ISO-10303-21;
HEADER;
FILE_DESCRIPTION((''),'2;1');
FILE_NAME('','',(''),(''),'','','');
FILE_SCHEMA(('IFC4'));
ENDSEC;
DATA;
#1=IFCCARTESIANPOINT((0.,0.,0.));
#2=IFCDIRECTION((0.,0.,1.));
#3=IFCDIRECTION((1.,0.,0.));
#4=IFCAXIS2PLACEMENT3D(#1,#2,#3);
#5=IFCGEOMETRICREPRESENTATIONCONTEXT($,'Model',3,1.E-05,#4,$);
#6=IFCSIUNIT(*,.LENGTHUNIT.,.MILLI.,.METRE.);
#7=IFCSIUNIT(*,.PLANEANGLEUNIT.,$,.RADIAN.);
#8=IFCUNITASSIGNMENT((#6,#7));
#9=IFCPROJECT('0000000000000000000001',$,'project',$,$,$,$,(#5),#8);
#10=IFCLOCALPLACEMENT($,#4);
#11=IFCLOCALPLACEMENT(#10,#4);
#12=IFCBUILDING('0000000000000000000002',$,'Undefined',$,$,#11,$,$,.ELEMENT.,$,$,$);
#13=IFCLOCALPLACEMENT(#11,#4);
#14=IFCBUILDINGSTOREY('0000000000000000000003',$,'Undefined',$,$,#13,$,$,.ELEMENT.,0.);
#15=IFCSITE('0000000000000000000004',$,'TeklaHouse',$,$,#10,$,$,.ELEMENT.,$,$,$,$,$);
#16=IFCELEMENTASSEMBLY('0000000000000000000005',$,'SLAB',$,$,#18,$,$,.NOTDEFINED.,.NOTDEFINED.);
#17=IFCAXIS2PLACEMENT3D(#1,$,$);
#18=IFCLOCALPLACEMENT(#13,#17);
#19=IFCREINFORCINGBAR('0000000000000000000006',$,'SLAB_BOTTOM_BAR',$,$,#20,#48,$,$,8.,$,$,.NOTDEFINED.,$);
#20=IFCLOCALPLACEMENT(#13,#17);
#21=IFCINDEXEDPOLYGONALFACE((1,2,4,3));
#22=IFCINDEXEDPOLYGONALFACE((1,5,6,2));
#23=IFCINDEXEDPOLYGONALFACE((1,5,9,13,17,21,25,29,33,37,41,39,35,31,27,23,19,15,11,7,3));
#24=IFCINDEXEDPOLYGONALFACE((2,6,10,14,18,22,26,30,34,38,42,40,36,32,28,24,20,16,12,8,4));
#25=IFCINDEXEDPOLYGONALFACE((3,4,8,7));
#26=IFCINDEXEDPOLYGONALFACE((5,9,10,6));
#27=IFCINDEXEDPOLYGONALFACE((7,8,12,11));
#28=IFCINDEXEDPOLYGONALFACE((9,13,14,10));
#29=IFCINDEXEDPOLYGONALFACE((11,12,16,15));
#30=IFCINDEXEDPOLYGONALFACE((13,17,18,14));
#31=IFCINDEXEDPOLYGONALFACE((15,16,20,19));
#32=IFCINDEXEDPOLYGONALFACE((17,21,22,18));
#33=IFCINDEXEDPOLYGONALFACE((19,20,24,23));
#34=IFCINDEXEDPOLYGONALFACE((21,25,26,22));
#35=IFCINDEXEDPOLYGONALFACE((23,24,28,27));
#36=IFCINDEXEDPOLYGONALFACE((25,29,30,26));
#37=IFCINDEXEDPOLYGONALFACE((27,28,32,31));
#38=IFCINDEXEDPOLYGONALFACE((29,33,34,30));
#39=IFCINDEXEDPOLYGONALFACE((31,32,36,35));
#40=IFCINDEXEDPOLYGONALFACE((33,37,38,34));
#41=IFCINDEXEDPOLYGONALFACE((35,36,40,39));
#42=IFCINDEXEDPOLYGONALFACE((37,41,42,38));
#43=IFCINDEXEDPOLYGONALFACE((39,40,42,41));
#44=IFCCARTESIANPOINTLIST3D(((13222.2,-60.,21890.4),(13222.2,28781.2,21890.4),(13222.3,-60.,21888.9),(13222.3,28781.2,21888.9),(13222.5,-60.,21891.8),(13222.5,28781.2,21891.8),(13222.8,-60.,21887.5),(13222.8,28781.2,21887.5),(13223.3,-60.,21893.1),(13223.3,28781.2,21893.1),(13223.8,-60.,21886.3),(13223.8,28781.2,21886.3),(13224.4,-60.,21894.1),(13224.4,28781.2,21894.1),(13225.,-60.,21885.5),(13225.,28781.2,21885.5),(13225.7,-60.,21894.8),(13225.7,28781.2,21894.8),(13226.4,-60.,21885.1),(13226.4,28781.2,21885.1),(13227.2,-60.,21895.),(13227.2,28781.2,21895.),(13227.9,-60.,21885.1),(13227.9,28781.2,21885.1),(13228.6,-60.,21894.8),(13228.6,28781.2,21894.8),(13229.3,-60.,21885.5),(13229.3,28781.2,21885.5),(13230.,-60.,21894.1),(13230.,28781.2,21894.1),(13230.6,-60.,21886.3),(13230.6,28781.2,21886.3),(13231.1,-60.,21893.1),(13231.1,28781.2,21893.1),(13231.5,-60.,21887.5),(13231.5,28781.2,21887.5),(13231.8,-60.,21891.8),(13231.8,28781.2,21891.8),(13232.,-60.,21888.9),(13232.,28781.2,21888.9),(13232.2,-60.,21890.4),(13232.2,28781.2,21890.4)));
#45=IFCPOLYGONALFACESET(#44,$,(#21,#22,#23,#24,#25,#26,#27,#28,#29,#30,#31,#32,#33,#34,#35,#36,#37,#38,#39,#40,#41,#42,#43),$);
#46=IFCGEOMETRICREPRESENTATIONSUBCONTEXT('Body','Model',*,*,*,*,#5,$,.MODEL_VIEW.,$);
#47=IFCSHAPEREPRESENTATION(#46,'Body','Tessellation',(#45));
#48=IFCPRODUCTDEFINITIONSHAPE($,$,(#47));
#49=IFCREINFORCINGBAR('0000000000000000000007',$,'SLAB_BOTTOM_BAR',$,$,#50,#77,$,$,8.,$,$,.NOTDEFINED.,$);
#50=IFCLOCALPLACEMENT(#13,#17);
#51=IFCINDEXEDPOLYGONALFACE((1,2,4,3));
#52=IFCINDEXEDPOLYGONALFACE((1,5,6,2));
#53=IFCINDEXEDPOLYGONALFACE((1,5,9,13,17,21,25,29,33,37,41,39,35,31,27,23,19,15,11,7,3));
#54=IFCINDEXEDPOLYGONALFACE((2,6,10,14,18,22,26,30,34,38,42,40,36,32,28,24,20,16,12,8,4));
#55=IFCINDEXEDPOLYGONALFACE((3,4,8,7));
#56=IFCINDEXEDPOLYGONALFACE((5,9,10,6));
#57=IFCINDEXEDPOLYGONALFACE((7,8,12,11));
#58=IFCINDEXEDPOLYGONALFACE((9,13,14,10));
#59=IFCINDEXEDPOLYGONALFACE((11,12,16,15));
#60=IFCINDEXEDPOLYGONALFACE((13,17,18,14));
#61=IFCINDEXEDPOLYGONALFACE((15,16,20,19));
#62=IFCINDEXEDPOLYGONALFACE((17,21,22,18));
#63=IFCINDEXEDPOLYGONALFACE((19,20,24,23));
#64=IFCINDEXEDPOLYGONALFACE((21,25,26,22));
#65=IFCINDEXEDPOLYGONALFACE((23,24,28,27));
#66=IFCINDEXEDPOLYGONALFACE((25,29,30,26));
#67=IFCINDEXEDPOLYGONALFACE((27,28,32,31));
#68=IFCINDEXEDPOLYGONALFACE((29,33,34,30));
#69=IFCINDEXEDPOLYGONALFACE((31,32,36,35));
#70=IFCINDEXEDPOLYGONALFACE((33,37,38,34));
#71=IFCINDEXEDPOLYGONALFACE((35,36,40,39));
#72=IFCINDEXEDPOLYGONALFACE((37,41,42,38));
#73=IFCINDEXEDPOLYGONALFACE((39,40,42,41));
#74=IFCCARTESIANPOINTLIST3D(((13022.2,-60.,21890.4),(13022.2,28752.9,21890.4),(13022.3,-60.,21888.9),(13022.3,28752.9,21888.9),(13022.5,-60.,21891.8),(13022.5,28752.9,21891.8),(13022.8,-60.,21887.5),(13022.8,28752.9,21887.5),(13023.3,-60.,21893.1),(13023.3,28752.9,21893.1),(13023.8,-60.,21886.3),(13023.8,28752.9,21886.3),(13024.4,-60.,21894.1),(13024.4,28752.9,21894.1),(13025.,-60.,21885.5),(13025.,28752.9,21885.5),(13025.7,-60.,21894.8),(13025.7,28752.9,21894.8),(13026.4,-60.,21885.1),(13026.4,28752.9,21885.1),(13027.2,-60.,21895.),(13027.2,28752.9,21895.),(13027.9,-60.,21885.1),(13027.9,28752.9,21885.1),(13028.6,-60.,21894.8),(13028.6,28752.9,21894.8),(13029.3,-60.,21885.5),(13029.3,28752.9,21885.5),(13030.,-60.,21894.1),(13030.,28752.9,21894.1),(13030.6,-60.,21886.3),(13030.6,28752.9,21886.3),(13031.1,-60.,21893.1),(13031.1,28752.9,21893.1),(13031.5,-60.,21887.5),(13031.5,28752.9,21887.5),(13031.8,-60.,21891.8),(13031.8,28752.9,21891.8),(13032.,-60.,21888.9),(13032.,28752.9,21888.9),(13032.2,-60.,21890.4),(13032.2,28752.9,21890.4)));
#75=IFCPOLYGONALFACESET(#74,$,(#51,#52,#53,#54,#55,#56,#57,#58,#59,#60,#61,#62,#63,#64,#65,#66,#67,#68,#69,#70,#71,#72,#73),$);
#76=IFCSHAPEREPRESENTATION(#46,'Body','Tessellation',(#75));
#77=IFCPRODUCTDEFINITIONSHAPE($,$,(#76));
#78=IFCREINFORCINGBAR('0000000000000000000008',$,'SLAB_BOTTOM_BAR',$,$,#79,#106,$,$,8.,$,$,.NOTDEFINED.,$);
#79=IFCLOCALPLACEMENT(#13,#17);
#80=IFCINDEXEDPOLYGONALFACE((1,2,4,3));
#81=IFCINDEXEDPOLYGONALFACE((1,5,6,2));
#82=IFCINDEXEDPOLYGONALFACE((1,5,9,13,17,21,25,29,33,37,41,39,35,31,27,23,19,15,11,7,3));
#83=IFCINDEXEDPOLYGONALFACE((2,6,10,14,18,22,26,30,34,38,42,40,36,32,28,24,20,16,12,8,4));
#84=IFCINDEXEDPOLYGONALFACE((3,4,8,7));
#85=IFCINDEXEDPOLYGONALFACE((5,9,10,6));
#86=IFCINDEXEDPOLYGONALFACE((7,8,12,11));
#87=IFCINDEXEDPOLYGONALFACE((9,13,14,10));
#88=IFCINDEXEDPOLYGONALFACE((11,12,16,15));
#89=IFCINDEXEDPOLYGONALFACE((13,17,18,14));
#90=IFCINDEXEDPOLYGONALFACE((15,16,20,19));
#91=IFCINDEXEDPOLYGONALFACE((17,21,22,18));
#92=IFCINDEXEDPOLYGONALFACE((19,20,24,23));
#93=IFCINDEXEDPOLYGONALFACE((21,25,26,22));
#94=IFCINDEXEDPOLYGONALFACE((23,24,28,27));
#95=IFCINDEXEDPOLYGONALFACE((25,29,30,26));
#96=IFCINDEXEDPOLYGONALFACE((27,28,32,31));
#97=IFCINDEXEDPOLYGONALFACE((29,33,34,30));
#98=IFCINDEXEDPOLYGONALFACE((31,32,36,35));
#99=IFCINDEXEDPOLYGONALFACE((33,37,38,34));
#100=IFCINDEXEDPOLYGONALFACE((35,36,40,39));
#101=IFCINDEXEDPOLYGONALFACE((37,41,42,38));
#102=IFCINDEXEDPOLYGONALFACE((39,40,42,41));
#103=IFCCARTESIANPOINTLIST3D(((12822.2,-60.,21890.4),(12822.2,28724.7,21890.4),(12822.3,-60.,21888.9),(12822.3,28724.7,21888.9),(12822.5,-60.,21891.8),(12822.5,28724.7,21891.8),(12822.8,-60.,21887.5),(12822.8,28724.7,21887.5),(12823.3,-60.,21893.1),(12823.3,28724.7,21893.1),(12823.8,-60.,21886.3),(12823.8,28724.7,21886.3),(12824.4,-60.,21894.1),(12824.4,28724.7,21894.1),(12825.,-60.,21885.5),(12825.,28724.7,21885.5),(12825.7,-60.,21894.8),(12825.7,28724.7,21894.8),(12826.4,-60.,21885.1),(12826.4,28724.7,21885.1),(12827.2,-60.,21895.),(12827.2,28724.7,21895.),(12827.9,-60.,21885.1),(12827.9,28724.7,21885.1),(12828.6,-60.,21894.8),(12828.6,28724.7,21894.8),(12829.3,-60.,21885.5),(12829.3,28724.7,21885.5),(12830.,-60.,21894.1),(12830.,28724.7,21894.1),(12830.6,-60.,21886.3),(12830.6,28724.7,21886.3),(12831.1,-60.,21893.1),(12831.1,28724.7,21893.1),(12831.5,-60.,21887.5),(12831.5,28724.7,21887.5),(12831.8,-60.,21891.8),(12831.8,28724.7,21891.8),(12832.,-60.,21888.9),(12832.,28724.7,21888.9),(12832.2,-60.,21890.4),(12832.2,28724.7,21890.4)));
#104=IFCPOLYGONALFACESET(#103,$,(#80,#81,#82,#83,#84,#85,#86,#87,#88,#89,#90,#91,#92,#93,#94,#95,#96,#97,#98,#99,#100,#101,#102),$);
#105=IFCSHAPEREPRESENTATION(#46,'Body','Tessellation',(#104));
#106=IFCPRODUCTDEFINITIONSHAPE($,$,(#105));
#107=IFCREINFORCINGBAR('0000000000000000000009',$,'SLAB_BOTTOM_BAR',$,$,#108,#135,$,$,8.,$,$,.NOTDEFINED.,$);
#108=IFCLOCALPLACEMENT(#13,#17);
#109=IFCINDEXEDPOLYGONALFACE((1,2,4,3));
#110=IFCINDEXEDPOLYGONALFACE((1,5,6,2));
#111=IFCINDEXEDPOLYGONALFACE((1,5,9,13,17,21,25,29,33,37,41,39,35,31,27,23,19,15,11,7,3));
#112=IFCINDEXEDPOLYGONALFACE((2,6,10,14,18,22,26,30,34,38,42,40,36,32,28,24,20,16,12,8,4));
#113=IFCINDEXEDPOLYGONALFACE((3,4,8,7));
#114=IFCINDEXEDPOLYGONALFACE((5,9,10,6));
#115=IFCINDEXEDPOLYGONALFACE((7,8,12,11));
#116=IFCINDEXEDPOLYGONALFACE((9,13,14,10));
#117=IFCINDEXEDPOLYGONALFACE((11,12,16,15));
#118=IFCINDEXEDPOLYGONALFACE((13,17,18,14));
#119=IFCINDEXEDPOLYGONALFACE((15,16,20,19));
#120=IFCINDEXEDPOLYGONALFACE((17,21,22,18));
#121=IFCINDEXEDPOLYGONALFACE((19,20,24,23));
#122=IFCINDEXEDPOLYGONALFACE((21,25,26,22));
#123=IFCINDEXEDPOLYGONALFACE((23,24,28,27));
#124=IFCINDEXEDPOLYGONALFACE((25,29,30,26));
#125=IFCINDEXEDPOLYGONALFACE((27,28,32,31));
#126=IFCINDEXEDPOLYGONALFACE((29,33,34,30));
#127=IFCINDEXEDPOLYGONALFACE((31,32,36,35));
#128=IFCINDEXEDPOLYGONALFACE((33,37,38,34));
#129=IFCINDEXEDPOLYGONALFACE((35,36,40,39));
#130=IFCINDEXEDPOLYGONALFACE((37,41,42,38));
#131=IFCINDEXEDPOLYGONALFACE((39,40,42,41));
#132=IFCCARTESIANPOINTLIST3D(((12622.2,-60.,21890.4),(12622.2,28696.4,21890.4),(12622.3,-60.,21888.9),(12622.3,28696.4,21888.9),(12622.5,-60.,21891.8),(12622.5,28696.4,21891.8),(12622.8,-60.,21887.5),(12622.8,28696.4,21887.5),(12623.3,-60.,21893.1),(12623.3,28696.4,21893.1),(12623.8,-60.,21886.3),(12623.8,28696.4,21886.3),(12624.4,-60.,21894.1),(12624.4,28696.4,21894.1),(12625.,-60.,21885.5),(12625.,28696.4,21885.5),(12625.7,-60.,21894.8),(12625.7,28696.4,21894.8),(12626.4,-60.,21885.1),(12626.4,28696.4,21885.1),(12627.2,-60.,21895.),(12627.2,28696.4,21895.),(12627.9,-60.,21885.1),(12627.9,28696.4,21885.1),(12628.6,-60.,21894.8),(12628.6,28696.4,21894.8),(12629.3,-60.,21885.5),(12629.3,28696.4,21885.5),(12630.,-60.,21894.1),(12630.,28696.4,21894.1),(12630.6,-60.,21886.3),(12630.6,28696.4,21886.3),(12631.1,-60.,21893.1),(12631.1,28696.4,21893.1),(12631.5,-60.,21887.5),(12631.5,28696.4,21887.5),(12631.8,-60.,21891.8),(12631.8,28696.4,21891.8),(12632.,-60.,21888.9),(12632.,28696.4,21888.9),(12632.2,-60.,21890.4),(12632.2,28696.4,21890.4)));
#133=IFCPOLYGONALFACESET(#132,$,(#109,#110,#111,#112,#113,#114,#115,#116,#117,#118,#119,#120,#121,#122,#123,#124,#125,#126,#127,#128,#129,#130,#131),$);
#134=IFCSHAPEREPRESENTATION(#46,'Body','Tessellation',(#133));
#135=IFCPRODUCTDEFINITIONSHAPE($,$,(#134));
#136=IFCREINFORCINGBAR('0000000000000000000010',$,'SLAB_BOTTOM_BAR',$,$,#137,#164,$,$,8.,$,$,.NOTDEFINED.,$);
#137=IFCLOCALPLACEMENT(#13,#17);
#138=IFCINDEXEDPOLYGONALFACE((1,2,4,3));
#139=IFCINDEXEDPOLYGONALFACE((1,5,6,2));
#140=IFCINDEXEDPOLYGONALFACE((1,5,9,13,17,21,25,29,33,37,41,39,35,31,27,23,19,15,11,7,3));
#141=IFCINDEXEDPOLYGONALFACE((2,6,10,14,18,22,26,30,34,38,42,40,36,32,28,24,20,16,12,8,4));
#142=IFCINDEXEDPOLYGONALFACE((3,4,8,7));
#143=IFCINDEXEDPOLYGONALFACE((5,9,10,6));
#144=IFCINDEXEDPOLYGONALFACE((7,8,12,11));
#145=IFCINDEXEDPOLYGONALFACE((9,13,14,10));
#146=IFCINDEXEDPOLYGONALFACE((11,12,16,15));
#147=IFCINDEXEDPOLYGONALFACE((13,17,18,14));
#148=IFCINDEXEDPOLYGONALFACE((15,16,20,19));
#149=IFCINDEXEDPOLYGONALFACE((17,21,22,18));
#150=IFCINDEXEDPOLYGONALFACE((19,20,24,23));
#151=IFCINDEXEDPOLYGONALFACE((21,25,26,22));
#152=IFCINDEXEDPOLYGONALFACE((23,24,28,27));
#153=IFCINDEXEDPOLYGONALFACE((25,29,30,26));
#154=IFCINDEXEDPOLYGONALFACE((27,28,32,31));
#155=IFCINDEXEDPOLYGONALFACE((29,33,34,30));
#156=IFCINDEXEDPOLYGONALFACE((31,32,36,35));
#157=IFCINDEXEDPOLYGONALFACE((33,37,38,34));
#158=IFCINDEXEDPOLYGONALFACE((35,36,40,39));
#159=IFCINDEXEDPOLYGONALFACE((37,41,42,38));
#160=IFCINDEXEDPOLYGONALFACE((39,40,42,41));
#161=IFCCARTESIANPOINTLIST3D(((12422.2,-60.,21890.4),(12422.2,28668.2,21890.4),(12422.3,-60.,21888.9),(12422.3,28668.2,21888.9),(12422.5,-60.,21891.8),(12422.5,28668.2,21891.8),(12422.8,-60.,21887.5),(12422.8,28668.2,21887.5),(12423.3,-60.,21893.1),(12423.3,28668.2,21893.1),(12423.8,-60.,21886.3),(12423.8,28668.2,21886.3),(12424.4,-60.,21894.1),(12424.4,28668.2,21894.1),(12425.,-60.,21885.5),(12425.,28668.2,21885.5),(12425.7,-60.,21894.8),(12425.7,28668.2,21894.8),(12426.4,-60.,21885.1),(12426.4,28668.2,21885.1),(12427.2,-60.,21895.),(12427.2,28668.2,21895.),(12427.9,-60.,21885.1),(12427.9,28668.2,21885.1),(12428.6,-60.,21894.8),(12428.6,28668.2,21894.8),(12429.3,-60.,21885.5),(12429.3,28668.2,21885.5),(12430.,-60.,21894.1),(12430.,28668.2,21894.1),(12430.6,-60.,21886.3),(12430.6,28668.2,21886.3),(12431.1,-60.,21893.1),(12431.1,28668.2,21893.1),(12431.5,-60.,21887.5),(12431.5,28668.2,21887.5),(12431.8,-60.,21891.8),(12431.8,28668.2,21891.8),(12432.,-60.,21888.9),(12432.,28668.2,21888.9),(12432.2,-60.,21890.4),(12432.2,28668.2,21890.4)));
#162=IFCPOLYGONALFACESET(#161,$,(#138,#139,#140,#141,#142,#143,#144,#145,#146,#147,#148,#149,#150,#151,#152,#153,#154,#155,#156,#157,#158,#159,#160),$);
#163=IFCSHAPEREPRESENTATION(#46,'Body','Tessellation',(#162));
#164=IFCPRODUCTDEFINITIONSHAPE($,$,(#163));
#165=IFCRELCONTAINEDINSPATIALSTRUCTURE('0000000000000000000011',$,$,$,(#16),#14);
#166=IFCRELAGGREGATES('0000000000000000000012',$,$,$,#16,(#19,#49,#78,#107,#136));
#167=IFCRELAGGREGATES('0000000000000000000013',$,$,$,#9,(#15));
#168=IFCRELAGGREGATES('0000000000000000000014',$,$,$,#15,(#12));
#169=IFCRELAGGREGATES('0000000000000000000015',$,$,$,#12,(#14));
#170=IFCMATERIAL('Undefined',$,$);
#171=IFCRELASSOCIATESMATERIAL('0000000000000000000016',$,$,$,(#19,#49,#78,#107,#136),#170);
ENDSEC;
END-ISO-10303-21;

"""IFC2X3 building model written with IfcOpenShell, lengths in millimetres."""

from ifc_helpers import new_model, entity, si_unit, frame, origin_with_axes, place, context, subcontext, project, spatial, source, transform, mapped, material, element, aggregate, save


model = new_model("IFC2X3")

# Units and contexts
model_context = context("Model", 3, precision=1e-05, world=origin_with_axes())
body_context = subcontext(model_context, "Body", "Model", "MODEL_VIEW")
ifc_project = project(units=[si_unit("LENGTHUNIT", "METRE", prefix="MILLI"), si_unit("PLANEANGLEUNIT", "RADIAN")], contexts=[model_context])

# Site, building, storey
site_placement = place(None, origin_with_axes())
site = spatial("IfcSite", under=ifc_project, at=site_placement, Name="TeklaHouse", CompositionType="ELEMENT")
building_placement = place(site_placement, origin_with_axes())
building = spatial("IfcBuilding", under=site, at=building_placement, Name="Undefined", CompositionType="ELEMENT")
storey_placement = place(building_placement, origin_with_axes())
storey = spatial("IfcBuildingStorey", under=building, at=storey_placement, Name="Undefined", CompositionType="ELEMENT", Elevation=0.0)

# Shared definitions
ifc_material_1 = material(Name="Undefined")

# Element assembly, reinforcing bars
assembly_1_placement = place(storey_placement, origin_with_axes())
assembly_1 = element("IfcElementAssembly", 1, at=assembly_1_placement, inside=storey, Name="SLAB", AssemblyPlace="NOTDEFINED", PredefinedType="NOTDEFINED")
shared_shape_1 = source(origin_with_axes(), body_context, "Body", "AdvancedSweptSolid", [
    entity("IfcSweptDiskSolid", entity("IfcTrimmedCurve", entity("IfcLine", entity("IfcCartesianPoint", [0.0, 0.0, 0.0]), entity("IfcVector", entity("IfcDirection", [1.0, 0.0, 0.0]), 1.0)), [entity("IfcParameterValue", 0.0)], [entity("IfcParameterValue", 28841.152806)], True, "PARAMETER"), 5.0, None, 0.0, 28841.2),
])
reinforcing_bar_1_placement = place(assembly_1_placement, frame((13227.2, -60.0, 21890.0), z_axis=(0.0, 0.0, 1.0), x_axis=(0.0, 1.0, 0.0)))
reinforcing_bar_1 = element("IfcReinforcingBar", 2, at=reinforcing_bar_1_placement, material=ifc_material_1, Name="SLAB_BOTTOM_BAR", BarRole="NOTDEFINED", NominalDiameter=8.0, context=body_context, shape_type="MappedRepresentation", body=[
    mapped(shared_shape_1, transform((0.0, 0.0, 0.0))),
])
shared_shape_2 = source(origin_with_axes(), body_context, "Body", "AdvancedSweptSolid", [
    entity("IfcSweptDiskSolid", entity("IfcTrimmedCurve", entity("IfcLine", entity("IfcCartesianPoint", [0.0, 0.0, 0.0]), entity("IfcVector", entity("IfcDirection", [1.0, 0.0, 0.0]), 1.0)), [entity("IfcParameterValue", 0.0)], [entity("IfcParameterValue", 28812.910695)], True, "PARAMETER"), 5.0, None, 0.0, 28812.9),
])
reinforcing_bar_2_placement = place(assembly_1_placement, frame((13027.2, -60.0, 21890.0), z_axis=(0.0, 0.0, 1.0), x_axis=(0.0, 1.0, 0.0)))
reinforcing_bar_2 = element("IfcReinforcingBar", 3, at=reinforcing_bar_2_placement, material=ifc_material_1, Name="SLAB_BOTTOM_BAR", BarRole="NOTDEFINED", NominalDiameter=8.0, context=body_context, shape_type="MappedRepresentation", body=[
    mapped(shared_shape_2, transform((0.0, 0.0, 0.0))),
])
shared_shape_3 = source(origin_with_axes(), body_context, "Body", "AdvancedSweptSolid", [
    entity("IfcSweptDiskSolid", entity("IfcTrimmedCurve", entity("IfcLine", entity("IfcCartesianPoint", [0.0, 0.0, 0.0]), entity("IfcVector", entity("IfcDirection", [1.0, 0.0, 0.0]), 1.0)), [entity("IfcParameterValue", 0.0)], [entity("IfcParameterValue", 28784.668584)], True, "PARAMETER"), 5.0, None, 0.0, 28784.7),
])
reinforcing_bar_3_placement = place(assembly_1_placement, frame((12827.2, -60.0, 21890.0), z_axis=(0.0, 0.0, 1.0), x_axis=(0.0, 1.0, 0.0)))
reinforcing_bar_3 = element("IfcReinforcingBar", 4, at=reinforcing_bar_3_placement, material=ifc_material_1, Name="SLAB_BOTTOM_BAR", BarRole="NOTDEFINED", NominalDiameter=8.0, context=body_context, shape_type="MappedRepresentation", body=[
    mapped(shared_shape_3, transform((0.0, 0.0, 0.0))),
])
shared_shape_4 = source(origin_with_axes(), body_context, "Body", "AdvancedSweptSolid", [
    entity("IfcSweptDiskSolid", entity("IfcTrimmedCurve", entity("IfcLine", entity("IfcCartesianPoint", [0.0, 0.0, 0.0]), entity("IfcVector", entity("IfcDirection", [1.0, 0.0, 0.0]), 1.0)), [entity("IfcParameterValue", 0.0)], [entity("IfcParameterValue", 28756.426473)], True, "PARAMETER"), 5.0, None, 0.0, 28756.4),
])
reinforcing_bar_4_placement = place(assembly_1_placement, frame((12627.2, -60.0, 21890.0), z_axis=(0.0, 0.0, 1.0), x_axis=(0.0, 1.0, 0.0)))
reinforcing_bar_4 = element("IfcReinforcingBar", 5, at=reinforcing_bar_4_placement, material=ifc_material_1, Name="SLAB_BOTTOM_BAR", BarRole="NOTDEFINED", NominalDiameter=8.0, context=body_context, shape_type="MappedRepresentation", body=[
    mapped(shared_shape_4, transform((0.0, 0.0, 0.0))),
])
shared_shape_5 = source(origin_with_axes(), body_context, "Body", "AdvancedSweptSolid", [
    entity("IfcSweptDiskSolid", entity("IfcTrimmedCurve", entity("IfcLine", entity("IfcCartesianPoint", [0.0, 0.0, 0.0]), entity("IfcVector", entity("IfcDirection", [1.0, 0.0, 0.0]), 1.0)), [entity("IfcParameterValue", 0.0)], [entity("IfcParameterValue", 28728.184363)], True, "PARAMETER"), 5.0, None, 0.0, 28728.2),
])
reinforcing_bar_5_placement = place(assembly_1_placement, frame((12427.2, -60.0, 21890.0), z_axis=(0.0, 0.0, 1.0), x_axis=(0.0, 1.0, 0.0)))
reinforcing_bar_5 = element("IfcReinforcingBar", 6, at=reinforcing_bar_5_placement, material=ifc_material_1, Name="SLAB_BOTTOM_BAR", BarRole="NOTDEFINED", NominalDiameter=8.0, context=body_context, shape_type="MappedRepresentation", body=[
    mapped(shared_shape_5, transform((0.0, 0.0, 0.0))),
])
aggregate(assembly_1, [reinforcing_bar_1, reinforcing_bar_2, reinforcing_bar_3, reinforcing_bar_4, reinforcing_bar_5])

save(model, "model.ifc")
